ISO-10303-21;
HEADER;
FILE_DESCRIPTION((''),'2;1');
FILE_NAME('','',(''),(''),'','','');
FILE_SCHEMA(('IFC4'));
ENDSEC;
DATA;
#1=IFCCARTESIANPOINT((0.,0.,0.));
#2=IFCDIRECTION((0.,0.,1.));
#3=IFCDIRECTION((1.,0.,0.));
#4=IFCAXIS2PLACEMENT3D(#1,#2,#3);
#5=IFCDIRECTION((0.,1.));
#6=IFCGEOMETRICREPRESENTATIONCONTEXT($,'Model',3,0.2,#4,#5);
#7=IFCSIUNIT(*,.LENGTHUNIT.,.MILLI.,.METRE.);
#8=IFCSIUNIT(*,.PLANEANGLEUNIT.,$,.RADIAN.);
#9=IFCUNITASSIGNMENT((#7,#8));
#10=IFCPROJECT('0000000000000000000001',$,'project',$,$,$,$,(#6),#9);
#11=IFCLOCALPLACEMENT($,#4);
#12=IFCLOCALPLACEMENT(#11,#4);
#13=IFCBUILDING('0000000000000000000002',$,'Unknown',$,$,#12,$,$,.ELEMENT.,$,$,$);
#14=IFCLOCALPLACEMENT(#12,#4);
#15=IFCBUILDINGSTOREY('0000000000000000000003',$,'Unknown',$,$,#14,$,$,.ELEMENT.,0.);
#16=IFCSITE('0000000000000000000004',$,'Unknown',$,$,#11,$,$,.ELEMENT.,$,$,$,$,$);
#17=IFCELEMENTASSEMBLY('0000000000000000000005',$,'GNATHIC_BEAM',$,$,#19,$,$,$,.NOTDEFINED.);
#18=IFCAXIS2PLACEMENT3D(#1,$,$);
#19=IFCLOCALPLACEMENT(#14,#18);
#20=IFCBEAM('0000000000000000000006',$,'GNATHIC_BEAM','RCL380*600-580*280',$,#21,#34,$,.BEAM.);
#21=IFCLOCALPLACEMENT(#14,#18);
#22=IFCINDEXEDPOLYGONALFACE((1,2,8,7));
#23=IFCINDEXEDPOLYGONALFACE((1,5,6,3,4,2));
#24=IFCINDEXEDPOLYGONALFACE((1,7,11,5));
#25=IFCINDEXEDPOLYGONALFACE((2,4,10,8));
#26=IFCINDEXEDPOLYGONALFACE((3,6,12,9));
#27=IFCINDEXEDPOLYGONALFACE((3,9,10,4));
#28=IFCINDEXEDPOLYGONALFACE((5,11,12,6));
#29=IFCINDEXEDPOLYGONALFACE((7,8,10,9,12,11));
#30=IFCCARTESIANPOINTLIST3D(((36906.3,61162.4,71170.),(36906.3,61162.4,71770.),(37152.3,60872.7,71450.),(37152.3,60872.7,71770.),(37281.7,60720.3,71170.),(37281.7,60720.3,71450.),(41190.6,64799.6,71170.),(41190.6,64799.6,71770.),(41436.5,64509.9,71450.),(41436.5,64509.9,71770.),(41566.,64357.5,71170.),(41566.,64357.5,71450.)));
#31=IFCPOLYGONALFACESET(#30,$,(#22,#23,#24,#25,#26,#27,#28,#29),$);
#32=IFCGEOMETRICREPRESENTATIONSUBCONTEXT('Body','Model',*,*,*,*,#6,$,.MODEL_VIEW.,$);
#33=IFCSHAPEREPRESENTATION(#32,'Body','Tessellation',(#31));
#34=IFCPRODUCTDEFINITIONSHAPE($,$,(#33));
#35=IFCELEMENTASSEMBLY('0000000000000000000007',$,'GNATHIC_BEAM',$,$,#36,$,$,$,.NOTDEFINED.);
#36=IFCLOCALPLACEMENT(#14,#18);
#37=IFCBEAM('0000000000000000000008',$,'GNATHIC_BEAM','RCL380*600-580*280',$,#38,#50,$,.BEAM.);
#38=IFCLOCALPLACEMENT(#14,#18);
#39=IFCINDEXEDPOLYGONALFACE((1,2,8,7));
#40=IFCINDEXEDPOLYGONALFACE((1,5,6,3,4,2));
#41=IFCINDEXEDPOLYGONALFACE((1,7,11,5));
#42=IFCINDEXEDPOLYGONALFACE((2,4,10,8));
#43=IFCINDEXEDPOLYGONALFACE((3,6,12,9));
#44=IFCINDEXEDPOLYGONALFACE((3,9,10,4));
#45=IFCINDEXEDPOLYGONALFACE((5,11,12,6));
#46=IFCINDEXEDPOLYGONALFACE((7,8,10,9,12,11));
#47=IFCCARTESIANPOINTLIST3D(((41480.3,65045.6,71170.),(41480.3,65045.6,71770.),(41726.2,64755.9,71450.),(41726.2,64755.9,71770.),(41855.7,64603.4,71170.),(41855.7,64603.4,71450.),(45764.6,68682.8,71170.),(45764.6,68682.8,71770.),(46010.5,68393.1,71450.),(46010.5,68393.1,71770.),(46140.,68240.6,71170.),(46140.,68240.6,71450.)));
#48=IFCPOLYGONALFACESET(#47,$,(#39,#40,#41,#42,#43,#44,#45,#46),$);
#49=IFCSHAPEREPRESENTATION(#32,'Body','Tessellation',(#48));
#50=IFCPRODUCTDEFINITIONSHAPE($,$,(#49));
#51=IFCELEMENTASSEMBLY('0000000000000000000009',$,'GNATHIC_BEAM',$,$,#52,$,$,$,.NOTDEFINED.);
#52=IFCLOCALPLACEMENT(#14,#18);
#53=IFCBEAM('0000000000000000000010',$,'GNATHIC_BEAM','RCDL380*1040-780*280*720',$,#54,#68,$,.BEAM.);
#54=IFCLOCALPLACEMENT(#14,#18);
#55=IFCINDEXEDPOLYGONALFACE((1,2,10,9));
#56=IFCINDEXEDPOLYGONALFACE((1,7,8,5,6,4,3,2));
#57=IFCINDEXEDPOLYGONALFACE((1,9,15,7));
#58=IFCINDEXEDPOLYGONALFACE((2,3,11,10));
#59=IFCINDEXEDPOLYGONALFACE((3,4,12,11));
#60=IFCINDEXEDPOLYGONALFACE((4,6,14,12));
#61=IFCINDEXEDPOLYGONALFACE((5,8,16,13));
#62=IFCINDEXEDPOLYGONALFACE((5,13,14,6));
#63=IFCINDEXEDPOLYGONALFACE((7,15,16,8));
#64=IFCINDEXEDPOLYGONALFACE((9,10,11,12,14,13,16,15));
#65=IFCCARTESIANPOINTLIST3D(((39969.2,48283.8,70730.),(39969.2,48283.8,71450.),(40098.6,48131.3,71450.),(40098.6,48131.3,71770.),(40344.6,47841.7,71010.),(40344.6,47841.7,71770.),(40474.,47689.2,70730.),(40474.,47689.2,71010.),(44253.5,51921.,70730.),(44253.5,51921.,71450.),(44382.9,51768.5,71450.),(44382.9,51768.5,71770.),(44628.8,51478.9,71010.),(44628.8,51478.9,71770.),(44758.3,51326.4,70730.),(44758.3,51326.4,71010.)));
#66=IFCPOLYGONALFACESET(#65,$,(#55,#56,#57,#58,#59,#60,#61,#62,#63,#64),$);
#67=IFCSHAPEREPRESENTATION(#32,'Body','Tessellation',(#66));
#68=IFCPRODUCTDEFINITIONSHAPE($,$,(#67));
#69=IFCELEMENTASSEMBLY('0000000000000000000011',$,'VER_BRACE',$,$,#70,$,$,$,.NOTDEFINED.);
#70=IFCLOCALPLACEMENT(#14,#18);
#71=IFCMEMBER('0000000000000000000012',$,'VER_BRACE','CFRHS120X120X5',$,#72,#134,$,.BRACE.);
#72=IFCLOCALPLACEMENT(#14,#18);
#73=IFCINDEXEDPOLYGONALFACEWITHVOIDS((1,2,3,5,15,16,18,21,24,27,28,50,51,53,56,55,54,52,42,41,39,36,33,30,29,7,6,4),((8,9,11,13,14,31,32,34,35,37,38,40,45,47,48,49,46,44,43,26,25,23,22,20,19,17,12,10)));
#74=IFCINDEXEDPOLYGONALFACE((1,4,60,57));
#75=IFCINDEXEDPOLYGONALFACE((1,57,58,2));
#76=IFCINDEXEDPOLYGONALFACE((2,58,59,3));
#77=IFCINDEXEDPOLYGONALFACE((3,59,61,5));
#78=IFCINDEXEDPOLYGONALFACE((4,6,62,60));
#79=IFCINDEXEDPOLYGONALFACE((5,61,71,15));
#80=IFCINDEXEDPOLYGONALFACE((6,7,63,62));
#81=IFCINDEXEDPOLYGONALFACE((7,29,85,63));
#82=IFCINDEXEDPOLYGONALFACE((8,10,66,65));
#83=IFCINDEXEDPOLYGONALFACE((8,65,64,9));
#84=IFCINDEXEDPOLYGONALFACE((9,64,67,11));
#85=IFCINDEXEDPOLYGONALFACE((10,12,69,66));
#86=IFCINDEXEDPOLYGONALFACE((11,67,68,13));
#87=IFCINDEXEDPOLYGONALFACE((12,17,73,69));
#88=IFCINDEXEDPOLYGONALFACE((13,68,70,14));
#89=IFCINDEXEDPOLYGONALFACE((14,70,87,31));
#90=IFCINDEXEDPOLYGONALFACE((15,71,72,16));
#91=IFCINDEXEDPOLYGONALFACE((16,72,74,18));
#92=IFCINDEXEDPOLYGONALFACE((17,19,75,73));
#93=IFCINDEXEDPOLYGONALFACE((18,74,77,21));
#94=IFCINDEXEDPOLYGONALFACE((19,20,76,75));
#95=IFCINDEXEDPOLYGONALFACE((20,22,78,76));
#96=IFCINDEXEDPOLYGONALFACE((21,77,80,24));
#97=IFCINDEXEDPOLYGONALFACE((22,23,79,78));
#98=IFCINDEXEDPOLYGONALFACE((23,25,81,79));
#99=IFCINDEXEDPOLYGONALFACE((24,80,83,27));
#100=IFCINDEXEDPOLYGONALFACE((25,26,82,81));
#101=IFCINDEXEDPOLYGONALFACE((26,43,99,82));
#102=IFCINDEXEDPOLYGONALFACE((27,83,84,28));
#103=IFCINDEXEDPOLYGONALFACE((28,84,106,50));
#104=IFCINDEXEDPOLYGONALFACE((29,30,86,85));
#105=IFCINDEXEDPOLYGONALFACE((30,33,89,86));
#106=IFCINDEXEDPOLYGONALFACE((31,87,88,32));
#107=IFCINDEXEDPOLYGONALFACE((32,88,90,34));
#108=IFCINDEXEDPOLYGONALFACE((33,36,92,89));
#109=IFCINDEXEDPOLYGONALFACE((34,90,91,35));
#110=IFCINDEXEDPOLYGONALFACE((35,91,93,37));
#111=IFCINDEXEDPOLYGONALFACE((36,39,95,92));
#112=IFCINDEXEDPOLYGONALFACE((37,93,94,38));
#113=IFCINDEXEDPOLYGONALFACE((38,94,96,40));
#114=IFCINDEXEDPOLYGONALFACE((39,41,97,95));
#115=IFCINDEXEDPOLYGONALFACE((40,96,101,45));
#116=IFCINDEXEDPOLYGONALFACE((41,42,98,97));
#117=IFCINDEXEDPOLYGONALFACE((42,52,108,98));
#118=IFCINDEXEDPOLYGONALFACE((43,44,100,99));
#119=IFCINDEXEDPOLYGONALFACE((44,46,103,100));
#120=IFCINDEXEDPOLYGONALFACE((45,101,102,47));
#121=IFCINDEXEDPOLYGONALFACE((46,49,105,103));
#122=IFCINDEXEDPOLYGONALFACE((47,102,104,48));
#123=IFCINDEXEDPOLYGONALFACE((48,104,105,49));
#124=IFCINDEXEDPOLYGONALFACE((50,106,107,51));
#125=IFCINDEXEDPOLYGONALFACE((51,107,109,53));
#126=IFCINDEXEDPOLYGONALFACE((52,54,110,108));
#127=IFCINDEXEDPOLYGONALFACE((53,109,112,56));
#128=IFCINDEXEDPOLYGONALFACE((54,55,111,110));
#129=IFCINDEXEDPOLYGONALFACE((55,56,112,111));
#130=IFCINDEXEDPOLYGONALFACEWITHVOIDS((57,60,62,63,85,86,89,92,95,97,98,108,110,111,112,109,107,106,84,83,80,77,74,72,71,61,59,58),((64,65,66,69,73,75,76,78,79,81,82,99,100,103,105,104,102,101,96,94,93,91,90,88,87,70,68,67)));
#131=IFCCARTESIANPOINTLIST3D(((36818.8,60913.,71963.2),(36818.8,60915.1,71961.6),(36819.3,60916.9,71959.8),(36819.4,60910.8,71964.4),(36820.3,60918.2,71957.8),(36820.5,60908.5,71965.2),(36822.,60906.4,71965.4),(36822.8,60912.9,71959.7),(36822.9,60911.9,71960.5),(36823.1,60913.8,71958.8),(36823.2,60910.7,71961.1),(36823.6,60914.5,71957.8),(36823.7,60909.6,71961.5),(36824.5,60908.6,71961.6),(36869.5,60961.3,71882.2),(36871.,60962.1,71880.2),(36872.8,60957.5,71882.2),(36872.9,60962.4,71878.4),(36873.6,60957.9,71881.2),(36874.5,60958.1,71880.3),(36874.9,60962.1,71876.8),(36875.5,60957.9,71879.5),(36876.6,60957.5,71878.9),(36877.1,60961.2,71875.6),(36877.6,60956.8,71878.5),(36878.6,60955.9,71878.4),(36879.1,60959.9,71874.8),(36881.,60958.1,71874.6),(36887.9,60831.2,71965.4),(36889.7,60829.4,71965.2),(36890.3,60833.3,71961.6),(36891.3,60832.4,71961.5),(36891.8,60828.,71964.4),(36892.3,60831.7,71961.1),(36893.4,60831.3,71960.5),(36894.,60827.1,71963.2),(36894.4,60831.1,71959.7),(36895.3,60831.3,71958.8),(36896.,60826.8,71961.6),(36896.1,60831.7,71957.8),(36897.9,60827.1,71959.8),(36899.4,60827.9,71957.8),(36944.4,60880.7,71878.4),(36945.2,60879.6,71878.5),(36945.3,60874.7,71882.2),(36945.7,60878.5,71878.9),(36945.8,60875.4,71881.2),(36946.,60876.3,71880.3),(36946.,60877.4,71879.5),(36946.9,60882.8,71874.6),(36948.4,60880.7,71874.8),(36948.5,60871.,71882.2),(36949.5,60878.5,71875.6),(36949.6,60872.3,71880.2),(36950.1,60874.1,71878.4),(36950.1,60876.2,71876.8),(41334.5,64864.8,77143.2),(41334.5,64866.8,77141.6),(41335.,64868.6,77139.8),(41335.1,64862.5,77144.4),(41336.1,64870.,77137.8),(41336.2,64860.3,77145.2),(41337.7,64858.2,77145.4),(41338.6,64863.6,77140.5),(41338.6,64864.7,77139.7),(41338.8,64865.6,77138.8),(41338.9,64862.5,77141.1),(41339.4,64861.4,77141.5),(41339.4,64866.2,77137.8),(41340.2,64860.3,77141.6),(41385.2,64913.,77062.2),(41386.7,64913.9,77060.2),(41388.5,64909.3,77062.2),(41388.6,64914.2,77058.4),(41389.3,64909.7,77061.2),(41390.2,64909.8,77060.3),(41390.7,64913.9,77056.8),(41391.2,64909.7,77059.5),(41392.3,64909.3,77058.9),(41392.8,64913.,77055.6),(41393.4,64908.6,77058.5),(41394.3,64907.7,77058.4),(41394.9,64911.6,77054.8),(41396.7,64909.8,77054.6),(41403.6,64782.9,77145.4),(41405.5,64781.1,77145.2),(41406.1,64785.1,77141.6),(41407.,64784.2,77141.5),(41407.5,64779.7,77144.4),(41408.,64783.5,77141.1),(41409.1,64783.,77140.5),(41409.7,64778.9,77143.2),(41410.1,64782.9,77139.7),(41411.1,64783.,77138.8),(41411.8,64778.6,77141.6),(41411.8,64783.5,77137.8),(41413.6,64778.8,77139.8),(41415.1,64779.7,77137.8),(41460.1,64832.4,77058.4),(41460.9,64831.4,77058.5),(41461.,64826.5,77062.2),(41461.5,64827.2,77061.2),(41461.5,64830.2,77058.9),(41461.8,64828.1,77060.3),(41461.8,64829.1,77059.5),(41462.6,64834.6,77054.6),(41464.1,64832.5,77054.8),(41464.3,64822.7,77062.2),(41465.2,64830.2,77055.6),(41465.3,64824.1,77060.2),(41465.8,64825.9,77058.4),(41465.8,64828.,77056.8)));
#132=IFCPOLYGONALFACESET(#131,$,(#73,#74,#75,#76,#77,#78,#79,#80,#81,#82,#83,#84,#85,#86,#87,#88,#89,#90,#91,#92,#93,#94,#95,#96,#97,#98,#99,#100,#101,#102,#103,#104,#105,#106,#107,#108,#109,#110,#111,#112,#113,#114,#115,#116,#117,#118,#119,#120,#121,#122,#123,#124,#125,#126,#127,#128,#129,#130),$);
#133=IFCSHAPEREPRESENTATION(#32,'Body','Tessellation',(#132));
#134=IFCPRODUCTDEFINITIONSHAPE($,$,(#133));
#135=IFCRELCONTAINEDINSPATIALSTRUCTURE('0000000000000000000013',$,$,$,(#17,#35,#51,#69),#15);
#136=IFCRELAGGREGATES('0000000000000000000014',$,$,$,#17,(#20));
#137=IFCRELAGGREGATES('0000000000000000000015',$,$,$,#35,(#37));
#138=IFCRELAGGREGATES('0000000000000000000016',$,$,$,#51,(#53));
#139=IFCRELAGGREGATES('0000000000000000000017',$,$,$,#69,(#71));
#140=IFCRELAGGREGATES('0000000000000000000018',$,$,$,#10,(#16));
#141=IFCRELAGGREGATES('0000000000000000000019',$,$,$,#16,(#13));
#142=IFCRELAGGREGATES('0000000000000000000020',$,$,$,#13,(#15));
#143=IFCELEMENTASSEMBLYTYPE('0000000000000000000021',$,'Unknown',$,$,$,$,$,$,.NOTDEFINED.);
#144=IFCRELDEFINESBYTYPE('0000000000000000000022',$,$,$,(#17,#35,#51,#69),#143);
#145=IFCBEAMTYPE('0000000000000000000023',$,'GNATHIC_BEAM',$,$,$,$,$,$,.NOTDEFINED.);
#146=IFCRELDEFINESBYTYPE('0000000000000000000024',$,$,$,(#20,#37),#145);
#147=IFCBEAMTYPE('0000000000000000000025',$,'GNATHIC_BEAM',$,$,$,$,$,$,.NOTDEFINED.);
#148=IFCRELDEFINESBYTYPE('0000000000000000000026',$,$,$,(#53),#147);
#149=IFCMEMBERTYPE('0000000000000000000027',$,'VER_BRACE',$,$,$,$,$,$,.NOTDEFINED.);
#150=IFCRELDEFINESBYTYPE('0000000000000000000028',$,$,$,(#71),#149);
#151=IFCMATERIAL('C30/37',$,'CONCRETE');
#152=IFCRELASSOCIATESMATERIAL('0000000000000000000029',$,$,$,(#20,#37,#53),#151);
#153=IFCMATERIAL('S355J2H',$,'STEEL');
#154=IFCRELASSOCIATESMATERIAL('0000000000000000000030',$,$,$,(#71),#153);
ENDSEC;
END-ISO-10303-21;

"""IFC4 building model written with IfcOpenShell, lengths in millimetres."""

from ifc_helpers import new_model, si_unit, direction, frame, origin_with_axes, origin_2d_with_axis, place, context, subcontext, project, spatial, polyline, hollow_rectangle, outline, extrude, material, material_profile, profile_set, profile_usage, type_object, element, aggregate, save


model = new_model("IFC4")

# Units and contexts
model_context = context("Model", 3, precision=0.2, world=origin_with_axes(), true_north=direction((0.0, 1.0)))
body_context = subcontext(model_context, "Body", "Model", "MODEL_VIEW")
ifc_project = project(units=[si_unit("LENGTHUNIT", "METRE", prefix="MILLI"), si_unit("PLANEANGLEUNIT", "RADIAN")], contexts=[model_context])

# Site, building, storey
site_placement = place(None, origin_with_axes())
site = spatial("IfcSite", under=ifc_project, at=site_placement, Name="Unknown", CompositionType="ELEMENT")
building_placement = place(site_placement, origin_with_axes())
building = spatial("IfcBuilding", under=site, at=building_placement, Name="Unknown", CompositionType="ELEMENT")
storey_placement = place(building_placement, origin_with_axes())
storey = spatial("IfcBuildingStorey", under=building, at=storey_placement, Name="Unknown", CompositionType="ELEMENT", Elevation=0.0)

# Shared definitions
element_assembly_type = type_object("IfcElementAssemblyType", Name="Unknown", PredefinedType="NOTDEFINED")

# Element assemblies, beams
ifc_material_1 = material(Name="C30/37", Category="CONCRETE")
ifc_material_profile_1 = material_profile(ifc_material_1, outline(polyline([(-190.0, -300.0), (390.0, -300.0), (390.0, -20.0), (190.0, -20.0), (190.0, 300.0), (-190.0, 300.0), (-190.0, -300.0)])), Name="RCL380*600-580*280")
ifc_profile_set_1 = profile_set([ifc_material_profile_1])
ifc_profile_usage_1 = profile_usage(ifc_profile_set_1, cardinal=2)
beam_type_1 = type_object("IfcBeamType", Name="GNATHIC_BEAM")
assembly_1_placement = place(storey_placement, frame((37029.3, 61017.6, 71470.0), z_axis=(0.64719, -0.762329, 0.0), x_axis=(0.762329, 0.64719, 0.0)))
assembly_1 = element("IfcElementAssembly", 1, at=assembly_1_placement, inside=storey, type_object=element_assembly_type, Name="GNATHIC_BEAM", PredefinedType="NOTDEFINED")
beam_1_placement = place(assembly_1_placement, origin_with_axes())
beam_1 = element("IfcBeam", 2, at=beam_1_placement, type_object=beam_type_1, material=ifc_profile_usage_1, Name="GNATHIC_BEAM", Description="RCL380*600-580*280", PredefinedType="BEAM", context=body_context, shape_type="SolidModel", body=[
    extrude(outline(polyline([(-190.0, -300.0), (390.0, -300.0), (390.0, -20.0), (190.0, -20.0), (190.0, 300.0), (-190.0, 300.0), (-190.0, -300.0)])), frame((0.0, 0.0, 0.0), z_axis=(-1.0, 0.0, 0.0), x_axis=(0.0, 0.0, 1.0)), (0.0, 0.0, -1.0), 5620.0),
])
aggregate(assembly_1, [beam_1])
assembly_2_placement = place(storey_placement, frame((41603.3, 64900.7, 71470.0), z_axis=(0.64719, -0.762329, 0.0), x_axis=(0.762329, 0.64719, 0.0)))
assembly_2 = element("IfcElementAssembly", 3, at=assembly_2_placement, inside=storey, type_object=element_assembly_type, Name="GNATHIC_BEAM", PredefinedType="NOTDEFINED")
beam_2_placement = place(assembly_2_placement, origin_with_axes())
beam_2 = element("IfcBeam", 4, at=beam_2_placement, type_object=beam_type_1, material=ifc_profile_usage_1, Name="GNATHIC_BEAM", Description="RCL380*600-580*280", PredefinedType="BEAM", context=body_context, shape_type="SolidModel", body=[
    extrude(outline(polyline([(-190.0, -300.0), (390.0, -300.0), (390.0, -20.0), (190.0, -20.0), (190.0, 300.0), (-190.0, 300.0), (-190.0, -300.0)])), frame((0.0, 0.0, 0.0), z_axis=(-1.0, 0.0, 0.0), x_axis=(0.0, 0.0, 1.0)), (0.0, 0.0, -1.0), 5620.0),
])
aggregate(assembly_2, [beam_2])
assembly_3_placement = place(storey_placement, frame((40221.6, 47986.5, 71250.0), z_axis=(0.64719, -0.762329, 0.0), x_axis=(0.762329, 0.64719, 0.0)))
assembly_3 = element("IfcElementAssembly", 5, at=assembly_3_placement, inside=storey, type_object=element_assembly_type, Name="GNATHIC_BEAM", PredefinedType="NOTDEFINED")
ifc_material_profile_2 = material_profile(ifc_material_1, outline(polyline([(-390.0, -520.0), (390.0, -520.0), (390.0, -240.0), (190.0, -240.0), (190.0, 520.0), (-190.0, 520.0), (-190.0, 200.0), (-390.0, 200.0), (-390.0, -520.0)])), Name="RCDL380*1040-780*280*720")
ifc_profile_set_2 = profile_set([ifc_material_profile_2])
ifc_profile_usage_2 = profile_usage(ifc_profile_set_2, cardinal=2)
beam_type_2 = type_object("IfcBeamType", Name="GNATHIC_BEAM")
beam_3_placement = place(assembly_3_placement, origin_with_axes())
beam_3 = element("IfcBeam", 6, at=beam_3_placement, type_object=beam_type_2, material=ifc_profile_usage_2, Name="GNATHIC_BEAM", Description="RCDL380*1040-780*280*720", PredefinedType="BEAM", context=body_context, shape_type="SolidModel", body=[
    extrude(outline(polyline([(-390.0, -520.0), (390.0, -520.0), (390.0, -240.0), (190.0, -240.0), (190.0, 520.0), (-190.0, 520.0), (-190.0, 200.0), (-390.0, 200.0), (-390.0, -520.0)])), frame((0.0, 0.0, 0.0), z_axis=(-1.0, 0.0, 0.0), x_axis=(0.0, 0.0, 1.0)), (0.0, 0.0, -1.0), 5620.0),
])
aggregate(assembly_3, [beam_3])

# Element assembly, member
assembly_4_placement = place(storey_placement, frame((36884.4, 60894.6, 71920.0), z_axis=(0.658551, -0.752536, 0.0), x_axis=(0.56965, 0.498505, 0.653446)))
assembly_4 = element("IfcElementAssembly", 7, at=assembly_4_placement, inside=storey, type_object=element_assembly_type, Name="VER_BRACE", PredefinedType="NOTDEFINED")
ifc_material_2 = material(Name="S355J2H", Category="STEEL")
ifc_material_profile_3 = material_profile(ifc_material_2, hollow_rectangle(XDim=120.0, YDim=120.0, WallThickness=5.0, InnerFilletRadius=5.0, OuterFilletRadius=10.0, at=origin_2d_with_axis()), Name="CFRHS120X120X5")
ifc_profile_set_3 = profile_set([ifc_material_profile_3])
ifc_profile_usage_3 = profile_usage(ifc_profile_set_3, cardinal=5)
member_type = type_object("IfcMemberType", Name="VER_BRACE")
member_placement = place(assembly_4_placement, origin_with_axes())
member = element("IfcMember", 8, at=member_placement, type_object=member_type, material=ifc_profile_usage_3, Name="VER_BRACE", Description="CFRHS120X120X5", PredefinedType="BRACE", context=body_context, shape_type="SolidModel", body=[
    extrude(hollow_rectangle(XDim=120.0, YDim=120.0, WallThickness=5.0, InnerFilletRadius=5.0, OuterFilletRadius=10.0, at=origin_2d_with_axis()), frame((0.0, 0.0, 0.0), z_axis=(-1.0, 0.0, 0.0), x_axis=(0.0, 0.0, 1.0)), (0.0, 0.0, -1.0), 7927.2),
])
aggregate(assembly_4, [member])

save(model, "model.ifc")
